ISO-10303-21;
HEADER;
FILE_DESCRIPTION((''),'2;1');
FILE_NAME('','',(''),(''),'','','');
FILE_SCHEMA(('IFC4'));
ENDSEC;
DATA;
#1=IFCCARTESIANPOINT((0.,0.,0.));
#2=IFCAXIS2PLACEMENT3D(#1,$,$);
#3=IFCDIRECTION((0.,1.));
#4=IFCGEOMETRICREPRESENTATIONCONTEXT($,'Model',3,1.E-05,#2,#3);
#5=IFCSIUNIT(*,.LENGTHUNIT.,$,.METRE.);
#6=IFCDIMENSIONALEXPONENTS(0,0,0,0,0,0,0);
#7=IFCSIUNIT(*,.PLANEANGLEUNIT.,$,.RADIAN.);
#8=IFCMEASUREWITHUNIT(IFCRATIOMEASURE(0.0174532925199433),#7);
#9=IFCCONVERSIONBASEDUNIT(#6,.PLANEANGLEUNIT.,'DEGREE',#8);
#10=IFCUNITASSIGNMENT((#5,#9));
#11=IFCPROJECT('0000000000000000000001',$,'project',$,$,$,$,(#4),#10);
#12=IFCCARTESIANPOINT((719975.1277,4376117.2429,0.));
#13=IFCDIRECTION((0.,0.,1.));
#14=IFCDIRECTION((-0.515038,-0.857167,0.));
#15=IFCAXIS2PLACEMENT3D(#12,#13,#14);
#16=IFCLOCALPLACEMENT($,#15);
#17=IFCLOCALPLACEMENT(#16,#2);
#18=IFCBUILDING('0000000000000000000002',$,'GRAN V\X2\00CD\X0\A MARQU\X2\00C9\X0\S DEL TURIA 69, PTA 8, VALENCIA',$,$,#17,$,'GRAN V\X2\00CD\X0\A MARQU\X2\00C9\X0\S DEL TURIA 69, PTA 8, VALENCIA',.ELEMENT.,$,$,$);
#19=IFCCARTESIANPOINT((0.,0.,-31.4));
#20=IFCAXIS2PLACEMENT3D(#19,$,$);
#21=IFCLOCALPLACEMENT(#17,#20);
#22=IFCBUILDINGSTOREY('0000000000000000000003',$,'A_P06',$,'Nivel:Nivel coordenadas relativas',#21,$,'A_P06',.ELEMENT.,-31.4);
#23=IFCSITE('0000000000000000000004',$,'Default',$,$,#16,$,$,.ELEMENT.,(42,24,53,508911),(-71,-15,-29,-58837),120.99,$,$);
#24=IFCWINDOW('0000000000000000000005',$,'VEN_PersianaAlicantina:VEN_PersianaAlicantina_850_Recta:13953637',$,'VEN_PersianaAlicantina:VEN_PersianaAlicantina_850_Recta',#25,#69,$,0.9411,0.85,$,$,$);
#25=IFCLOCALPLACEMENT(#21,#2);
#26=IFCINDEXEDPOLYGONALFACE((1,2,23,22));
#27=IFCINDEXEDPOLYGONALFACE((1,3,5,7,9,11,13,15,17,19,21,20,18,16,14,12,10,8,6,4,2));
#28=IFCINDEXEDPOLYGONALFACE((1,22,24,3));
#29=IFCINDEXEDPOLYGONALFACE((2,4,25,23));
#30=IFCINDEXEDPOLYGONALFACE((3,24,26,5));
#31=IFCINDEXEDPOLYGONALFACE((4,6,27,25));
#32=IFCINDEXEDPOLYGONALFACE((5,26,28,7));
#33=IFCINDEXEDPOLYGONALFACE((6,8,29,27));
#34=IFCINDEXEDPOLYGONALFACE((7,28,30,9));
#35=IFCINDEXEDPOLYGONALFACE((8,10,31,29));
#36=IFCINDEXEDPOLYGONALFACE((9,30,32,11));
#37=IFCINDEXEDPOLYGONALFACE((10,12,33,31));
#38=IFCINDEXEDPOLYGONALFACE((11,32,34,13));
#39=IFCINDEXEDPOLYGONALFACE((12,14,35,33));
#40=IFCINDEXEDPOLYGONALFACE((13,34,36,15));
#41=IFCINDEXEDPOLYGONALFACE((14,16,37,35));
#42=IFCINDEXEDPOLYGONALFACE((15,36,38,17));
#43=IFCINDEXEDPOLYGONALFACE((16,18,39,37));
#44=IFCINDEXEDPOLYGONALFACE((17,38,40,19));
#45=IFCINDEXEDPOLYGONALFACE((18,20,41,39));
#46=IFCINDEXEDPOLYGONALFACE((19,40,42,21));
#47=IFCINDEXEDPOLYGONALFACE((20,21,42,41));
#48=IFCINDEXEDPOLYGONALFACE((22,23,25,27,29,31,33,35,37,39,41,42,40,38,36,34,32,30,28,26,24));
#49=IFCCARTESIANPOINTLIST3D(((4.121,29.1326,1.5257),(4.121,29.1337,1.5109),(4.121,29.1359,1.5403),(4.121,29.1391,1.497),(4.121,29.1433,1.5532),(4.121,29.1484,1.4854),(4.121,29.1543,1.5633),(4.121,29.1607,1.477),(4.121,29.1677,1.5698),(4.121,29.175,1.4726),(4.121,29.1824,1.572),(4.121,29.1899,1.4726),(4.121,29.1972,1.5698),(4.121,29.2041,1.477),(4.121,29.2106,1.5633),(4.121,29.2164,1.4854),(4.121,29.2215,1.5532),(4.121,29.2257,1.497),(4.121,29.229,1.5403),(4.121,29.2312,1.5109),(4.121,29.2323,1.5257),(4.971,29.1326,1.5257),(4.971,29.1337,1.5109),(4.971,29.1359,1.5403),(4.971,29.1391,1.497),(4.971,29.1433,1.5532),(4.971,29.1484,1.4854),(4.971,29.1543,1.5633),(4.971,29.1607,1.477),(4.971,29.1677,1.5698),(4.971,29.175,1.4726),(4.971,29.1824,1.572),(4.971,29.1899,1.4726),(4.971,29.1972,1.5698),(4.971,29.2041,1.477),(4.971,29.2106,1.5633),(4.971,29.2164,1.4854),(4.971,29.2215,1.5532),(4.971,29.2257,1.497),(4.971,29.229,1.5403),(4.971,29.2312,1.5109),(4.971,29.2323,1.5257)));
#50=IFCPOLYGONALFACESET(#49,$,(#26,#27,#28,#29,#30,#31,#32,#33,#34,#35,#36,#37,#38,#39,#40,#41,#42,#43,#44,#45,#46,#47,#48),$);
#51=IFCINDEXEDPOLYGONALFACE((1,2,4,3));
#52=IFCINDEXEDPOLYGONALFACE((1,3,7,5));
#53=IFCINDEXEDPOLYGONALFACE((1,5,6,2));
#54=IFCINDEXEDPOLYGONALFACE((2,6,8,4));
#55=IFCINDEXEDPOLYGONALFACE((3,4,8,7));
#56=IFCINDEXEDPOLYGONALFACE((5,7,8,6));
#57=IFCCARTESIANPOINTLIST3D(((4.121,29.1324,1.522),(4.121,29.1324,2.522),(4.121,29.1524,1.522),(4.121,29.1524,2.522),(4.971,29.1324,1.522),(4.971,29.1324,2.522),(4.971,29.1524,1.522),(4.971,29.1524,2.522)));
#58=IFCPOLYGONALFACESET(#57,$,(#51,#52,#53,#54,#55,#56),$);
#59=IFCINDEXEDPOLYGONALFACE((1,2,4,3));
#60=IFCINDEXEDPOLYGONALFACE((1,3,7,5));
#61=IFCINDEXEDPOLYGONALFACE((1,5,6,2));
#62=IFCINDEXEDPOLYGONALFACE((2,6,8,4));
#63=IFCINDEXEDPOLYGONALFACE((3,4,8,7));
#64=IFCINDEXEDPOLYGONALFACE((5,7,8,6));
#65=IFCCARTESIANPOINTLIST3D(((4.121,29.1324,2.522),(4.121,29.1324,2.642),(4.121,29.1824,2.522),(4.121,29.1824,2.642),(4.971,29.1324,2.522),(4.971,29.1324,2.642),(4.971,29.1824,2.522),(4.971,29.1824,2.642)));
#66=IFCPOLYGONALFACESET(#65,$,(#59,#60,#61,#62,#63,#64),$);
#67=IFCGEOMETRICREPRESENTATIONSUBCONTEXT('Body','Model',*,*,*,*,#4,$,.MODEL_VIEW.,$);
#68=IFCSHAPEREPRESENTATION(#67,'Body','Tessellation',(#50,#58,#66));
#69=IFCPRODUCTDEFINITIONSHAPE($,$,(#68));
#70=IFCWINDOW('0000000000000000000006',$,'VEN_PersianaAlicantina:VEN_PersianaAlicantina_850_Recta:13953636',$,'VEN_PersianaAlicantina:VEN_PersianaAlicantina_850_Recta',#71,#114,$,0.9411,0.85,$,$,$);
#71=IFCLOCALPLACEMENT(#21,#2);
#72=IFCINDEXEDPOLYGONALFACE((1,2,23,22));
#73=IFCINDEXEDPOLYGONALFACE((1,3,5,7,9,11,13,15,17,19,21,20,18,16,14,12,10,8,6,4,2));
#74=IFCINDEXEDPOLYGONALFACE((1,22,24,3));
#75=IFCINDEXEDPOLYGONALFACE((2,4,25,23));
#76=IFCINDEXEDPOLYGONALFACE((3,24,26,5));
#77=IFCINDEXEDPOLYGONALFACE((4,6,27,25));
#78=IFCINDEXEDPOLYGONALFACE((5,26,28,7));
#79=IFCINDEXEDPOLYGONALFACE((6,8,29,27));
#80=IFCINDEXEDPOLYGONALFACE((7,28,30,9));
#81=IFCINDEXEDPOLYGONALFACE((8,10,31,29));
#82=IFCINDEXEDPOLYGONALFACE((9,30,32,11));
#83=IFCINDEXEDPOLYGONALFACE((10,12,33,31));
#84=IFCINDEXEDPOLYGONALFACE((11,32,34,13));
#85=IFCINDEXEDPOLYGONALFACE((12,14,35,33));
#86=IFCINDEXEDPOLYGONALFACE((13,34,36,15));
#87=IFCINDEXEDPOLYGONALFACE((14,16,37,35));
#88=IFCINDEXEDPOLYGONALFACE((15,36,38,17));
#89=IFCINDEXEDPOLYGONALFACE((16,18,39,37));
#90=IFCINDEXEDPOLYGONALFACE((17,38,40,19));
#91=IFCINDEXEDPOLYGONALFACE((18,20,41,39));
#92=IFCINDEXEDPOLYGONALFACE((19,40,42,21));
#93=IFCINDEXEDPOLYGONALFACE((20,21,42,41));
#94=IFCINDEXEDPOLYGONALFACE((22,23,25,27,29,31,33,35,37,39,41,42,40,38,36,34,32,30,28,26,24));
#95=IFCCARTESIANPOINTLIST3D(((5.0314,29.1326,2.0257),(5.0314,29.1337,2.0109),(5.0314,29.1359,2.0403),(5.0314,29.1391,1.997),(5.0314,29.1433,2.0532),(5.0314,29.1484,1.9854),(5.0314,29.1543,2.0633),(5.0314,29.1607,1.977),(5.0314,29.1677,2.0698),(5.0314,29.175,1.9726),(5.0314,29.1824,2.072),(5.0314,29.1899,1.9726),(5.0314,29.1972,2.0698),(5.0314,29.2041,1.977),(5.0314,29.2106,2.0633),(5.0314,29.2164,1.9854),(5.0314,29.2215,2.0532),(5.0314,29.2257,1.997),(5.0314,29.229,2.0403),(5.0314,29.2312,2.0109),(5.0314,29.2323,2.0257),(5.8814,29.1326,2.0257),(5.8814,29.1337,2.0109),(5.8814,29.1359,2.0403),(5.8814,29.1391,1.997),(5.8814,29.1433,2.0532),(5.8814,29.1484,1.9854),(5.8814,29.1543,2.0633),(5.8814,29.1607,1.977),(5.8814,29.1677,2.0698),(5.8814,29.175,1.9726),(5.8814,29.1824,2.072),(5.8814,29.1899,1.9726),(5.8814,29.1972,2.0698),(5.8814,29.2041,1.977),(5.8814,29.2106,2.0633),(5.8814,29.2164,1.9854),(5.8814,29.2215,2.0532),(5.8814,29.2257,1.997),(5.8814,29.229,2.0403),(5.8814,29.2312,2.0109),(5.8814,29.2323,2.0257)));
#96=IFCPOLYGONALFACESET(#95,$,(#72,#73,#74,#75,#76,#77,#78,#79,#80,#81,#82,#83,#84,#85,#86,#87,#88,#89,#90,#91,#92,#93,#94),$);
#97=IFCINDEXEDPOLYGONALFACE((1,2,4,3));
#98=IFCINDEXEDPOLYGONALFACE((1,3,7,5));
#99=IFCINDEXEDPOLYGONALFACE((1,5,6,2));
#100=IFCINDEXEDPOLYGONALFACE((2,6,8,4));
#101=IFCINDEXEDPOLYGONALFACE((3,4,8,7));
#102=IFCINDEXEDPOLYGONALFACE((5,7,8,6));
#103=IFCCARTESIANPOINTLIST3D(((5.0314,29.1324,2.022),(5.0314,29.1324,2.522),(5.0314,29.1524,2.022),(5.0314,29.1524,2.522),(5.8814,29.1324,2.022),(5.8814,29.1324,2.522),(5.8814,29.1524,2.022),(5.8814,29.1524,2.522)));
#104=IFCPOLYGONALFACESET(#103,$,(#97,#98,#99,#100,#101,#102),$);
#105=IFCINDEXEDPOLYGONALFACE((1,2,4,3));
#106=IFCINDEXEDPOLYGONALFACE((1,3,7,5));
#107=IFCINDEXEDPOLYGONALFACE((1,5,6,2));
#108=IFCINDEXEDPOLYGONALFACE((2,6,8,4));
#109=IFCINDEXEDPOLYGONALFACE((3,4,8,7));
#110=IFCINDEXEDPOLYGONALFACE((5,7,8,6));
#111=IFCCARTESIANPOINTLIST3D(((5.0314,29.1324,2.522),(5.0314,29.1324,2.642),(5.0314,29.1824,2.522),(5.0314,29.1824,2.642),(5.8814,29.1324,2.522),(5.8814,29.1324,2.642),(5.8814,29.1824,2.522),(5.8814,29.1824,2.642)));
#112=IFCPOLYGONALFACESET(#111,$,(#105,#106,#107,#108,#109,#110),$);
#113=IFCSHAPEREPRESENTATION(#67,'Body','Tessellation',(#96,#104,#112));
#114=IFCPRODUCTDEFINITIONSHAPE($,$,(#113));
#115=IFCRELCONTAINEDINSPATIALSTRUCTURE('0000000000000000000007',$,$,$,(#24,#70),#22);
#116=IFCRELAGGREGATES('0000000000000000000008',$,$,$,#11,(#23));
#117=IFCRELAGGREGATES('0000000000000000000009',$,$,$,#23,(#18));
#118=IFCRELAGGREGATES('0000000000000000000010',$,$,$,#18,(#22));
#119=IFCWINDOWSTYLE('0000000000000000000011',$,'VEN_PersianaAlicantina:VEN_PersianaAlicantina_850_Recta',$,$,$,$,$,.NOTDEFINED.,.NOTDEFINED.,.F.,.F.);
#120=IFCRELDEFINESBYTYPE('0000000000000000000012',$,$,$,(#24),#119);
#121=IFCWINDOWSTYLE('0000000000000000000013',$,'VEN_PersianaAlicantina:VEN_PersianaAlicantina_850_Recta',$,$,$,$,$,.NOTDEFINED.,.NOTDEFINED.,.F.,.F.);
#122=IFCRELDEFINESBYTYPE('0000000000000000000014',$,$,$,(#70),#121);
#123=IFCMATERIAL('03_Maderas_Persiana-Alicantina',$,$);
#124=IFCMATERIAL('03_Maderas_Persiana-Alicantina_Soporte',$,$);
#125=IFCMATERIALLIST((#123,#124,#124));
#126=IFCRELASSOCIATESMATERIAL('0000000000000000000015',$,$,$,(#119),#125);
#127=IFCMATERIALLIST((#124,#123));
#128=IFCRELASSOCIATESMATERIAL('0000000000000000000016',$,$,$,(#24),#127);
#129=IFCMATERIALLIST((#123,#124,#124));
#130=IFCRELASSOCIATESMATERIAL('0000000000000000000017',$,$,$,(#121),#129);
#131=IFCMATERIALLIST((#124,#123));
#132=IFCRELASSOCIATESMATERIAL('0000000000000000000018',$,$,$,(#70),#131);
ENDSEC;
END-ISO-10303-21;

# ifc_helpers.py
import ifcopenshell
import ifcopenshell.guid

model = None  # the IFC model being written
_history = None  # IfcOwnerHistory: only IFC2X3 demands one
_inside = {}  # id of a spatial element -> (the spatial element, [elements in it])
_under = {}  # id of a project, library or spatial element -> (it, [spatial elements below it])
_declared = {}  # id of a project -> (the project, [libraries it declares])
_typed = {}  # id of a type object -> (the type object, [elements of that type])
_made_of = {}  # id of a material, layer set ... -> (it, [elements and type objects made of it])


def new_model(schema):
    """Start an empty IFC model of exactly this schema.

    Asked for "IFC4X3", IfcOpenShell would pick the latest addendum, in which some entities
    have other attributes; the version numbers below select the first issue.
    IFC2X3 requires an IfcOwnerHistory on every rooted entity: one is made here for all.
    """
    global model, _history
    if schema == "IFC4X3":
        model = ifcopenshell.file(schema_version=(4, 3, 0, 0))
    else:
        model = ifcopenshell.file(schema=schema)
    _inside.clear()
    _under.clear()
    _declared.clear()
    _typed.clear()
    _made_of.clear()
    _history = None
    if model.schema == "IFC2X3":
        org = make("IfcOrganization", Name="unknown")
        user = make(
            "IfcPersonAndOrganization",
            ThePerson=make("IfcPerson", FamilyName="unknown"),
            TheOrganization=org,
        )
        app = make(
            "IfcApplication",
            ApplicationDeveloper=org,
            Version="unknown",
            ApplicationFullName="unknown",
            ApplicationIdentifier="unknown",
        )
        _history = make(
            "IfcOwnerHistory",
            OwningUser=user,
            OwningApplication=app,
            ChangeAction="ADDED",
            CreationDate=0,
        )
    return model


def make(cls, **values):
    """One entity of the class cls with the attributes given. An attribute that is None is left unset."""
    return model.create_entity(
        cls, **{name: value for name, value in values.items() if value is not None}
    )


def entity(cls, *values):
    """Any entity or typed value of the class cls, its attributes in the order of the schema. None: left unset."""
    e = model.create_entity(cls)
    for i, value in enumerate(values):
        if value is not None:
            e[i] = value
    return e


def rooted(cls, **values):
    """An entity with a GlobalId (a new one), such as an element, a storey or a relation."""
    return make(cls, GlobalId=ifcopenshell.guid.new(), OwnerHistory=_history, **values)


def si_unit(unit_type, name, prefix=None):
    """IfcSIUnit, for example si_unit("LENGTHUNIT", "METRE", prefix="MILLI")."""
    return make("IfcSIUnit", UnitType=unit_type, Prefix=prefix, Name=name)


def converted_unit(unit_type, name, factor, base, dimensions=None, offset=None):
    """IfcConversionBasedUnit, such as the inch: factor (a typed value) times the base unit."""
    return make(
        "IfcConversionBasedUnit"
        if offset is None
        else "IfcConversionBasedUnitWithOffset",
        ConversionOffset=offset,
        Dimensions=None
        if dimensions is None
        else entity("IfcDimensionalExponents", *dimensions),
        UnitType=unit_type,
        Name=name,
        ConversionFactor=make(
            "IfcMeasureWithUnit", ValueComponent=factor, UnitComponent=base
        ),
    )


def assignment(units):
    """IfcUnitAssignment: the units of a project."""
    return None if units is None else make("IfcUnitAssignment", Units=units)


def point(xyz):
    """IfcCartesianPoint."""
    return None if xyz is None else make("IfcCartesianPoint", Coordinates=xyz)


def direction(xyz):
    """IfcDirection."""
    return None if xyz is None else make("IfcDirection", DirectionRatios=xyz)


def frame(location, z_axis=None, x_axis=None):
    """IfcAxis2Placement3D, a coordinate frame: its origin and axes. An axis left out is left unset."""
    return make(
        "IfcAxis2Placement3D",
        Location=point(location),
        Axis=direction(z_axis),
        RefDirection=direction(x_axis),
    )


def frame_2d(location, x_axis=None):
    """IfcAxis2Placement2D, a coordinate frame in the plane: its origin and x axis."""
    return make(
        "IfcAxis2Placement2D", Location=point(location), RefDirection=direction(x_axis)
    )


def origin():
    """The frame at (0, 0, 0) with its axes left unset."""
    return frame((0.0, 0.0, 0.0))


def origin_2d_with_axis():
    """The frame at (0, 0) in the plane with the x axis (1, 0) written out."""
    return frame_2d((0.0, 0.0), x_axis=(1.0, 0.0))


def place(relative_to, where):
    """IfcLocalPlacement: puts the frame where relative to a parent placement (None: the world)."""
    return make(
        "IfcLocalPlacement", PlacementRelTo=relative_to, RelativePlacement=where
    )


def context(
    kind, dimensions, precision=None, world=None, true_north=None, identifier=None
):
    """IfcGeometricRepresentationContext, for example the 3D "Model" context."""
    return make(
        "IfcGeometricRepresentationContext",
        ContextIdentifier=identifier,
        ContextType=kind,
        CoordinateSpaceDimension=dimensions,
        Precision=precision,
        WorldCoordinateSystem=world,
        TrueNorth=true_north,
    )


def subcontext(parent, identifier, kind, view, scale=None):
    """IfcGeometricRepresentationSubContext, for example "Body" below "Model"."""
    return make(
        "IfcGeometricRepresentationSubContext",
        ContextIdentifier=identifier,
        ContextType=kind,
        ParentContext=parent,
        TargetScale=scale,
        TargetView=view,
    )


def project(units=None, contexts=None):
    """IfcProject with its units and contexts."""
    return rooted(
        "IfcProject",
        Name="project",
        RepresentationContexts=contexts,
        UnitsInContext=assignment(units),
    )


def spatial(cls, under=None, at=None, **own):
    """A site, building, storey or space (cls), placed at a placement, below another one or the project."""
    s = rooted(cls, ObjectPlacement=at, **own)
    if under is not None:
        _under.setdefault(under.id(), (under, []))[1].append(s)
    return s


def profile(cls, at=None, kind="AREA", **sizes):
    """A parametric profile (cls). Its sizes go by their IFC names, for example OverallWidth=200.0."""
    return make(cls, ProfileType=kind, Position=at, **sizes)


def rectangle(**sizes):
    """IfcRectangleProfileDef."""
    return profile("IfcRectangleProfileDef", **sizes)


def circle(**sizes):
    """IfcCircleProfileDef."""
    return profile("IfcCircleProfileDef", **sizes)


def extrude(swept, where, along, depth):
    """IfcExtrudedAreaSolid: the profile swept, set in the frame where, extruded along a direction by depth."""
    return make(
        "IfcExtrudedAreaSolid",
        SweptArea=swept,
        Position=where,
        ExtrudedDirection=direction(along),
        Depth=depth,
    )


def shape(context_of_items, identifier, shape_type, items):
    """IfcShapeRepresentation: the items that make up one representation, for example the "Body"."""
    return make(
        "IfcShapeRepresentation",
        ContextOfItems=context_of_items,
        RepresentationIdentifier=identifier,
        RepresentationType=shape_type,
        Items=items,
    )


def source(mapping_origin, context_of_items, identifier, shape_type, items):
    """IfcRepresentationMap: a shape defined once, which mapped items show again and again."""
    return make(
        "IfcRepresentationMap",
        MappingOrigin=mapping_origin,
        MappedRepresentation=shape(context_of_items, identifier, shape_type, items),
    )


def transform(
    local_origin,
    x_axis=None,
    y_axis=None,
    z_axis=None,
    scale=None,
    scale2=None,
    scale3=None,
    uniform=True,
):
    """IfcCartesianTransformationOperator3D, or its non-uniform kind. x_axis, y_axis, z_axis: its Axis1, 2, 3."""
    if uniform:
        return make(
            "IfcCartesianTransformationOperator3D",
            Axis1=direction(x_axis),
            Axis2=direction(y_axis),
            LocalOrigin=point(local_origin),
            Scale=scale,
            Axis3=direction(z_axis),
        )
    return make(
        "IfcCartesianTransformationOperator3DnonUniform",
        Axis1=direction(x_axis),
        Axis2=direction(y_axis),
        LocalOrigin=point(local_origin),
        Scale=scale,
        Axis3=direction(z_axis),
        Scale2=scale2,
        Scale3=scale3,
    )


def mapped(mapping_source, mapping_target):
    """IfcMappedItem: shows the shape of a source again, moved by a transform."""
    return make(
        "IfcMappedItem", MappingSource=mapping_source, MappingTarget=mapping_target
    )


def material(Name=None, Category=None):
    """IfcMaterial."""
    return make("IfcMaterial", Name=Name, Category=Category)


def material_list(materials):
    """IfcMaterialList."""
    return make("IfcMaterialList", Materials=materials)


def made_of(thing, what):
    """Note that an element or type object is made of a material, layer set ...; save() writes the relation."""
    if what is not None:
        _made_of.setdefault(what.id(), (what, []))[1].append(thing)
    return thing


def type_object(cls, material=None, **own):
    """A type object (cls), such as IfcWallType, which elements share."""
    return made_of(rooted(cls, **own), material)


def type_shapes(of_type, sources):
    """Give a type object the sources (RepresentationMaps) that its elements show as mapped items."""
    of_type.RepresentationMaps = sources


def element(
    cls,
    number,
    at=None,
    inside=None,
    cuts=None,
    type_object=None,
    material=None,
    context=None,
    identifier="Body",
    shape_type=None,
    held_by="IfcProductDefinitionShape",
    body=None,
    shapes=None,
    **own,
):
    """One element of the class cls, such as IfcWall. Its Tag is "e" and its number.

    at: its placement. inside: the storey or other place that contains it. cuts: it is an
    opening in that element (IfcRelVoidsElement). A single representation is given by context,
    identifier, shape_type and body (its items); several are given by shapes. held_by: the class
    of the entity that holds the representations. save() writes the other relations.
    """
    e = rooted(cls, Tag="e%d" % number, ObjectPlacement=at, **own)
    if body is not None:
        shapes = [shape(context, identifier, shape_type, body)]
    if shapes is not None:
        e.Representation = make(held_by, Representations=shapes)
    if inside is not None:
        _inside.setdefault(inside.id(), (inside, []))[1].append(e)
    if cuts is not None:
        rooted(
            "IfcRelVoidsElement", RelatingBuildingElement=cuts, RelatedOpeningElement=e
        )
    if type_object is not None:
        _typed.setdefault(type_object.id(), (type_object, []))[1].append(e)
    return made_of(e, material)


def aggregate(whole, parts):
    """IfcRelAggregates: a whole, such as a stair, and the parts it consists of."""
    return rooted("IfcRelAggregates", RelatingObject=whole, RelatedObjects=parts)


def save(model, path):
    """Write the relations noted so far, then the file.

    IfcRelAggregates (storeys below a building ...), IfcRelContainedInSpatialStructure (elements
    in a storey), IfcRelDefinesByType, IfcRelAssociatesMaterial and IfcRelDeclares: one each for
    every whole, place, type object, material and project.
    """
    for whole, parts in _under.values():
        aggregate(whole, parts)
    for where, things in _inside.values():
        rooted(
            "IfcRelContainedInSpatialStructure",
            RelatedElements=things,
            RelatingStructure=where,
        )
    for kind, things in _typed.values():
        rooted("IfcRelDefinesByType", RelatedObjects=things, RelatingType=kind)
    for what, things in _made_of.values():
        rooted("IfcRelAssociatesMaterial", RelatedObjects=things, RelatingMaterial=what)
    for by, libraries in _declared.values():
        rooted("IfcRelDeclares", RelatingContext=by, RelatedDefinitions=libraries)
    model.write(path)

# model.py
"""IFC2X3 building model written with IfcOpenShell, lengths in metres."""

from ifc_helpers import new_model, entity, si_unit, converted_unit, direction, frame, frame_2d, origin, origin_2d_with_axis, place, context, subcontext, project, spatial, rectangle, circle, extrude, source, transform, mapped, material, material_list, type_object, type_shapes, element, save


model = new_model("IFC2X3")

# Units and contexts
model_context = context("Model", 3, precision=1e-05, world=origin(), true_north=direction((0.0, 1.0)))
body_context = subcontext(model_context, "Body", "Model", "MODEL_VIEW")
ifc_project = project(units=[si_unit("LENGTHUNIT", "METRE"), converted_unit("PLANEANGLEUNIT", "DEGREE", entity("IfcRatioMeasure", 0.0174532925199433), si_unit("PLANEANGLEUNIT", "RADIAN"), dimensions=[0, 0, 0, 0, 0, 0, 0])], contexts=[model_context])

# Site, building, storey
site_placement = place(None, frame((719975.1277, 4376117.2429, 0.0), z_axis=(0.0, 0.0, 1.0), x_axis=(-0.515038, -0.857167, 0.0)))
site = spatial("IfcSite", under=ifc_project, at=site_placement, Name="Default", CompositionType="ELEMENT", RefLatitude=(42, 24, 53, 508911), RefLongitude=(-71, -15, -29, -58837), RefElevation=120.99)
building_placement = place(site_placement, origin())
building = spatial("IfcBuilding", under=site, at=building_placement, Name="GRAN VÍA MARQUÉS DEL TURIA 69, PTA 8, VALENCIA", LongName="GRAN VÍA MARQUÉS DEL TURIA 69, PTA 8, VALENCIA", CompositionType="ELEMENT")
storey_placement = place(building_placement, frame((0.0, 0.0, -31.4)))
storey = spatial("IfcBuildingStorey", under=building, at=storey_placement, Name="A_P06", ObjectType="Nivel:Nivel coordenadas relativas", LongName="A_P06", CompositionType="ELEMENT", Elevation=-31.4)

# Windows
ifc_material_1 = material(Name="03_Maderas_Persiana-Alicantina_Soporte")
ifc_material_2 = material(Name="03_Maderas_Persiana-Alicantina")
ifc_material_list_1 = material_list([ifc_material_1, ifc_material_2])
ifc_material_list_2 = material_list([ifc_material_2, ifc_material_1, ifc_material_1])
window_style_1 = type_object("IfcWindowStyle", Name="VEN_PersianaAlicantina:VEN_PersianaAlicantina_850_Recta", ConstructionType="NOTDEFINED", OperationType="NOTDEFINED", ParameterTakesPrecedence=False, Sizeable=False, material=ifc_material_list_2)
shared_shape_1 = source(origin(), body_context, "Body", "SweptSolid", [
    extrude(circle(Radius=0.05, at=frame_2d((0.0, 0.0), x_axis=(1.0, 0.0))), frame((-0.425, -0.5392, 0.05), z_axis=(1.0, 0.0, 0.0), x_axis=(0.0, 1.0, 0.0)), (0.0, 0.0, 1.0), 0.85),
    extrude(rectangle(XDim=0.85, YDim=1.0, at=frame_2d((0.0, 0.0), x_axis=(1.0, 0.0))), frame((0.0, -0.0392, 0.0), z_axis=(0.0, 0.0, 1.0), x_axis=(-1.0, 0.0, 0.0)), (0.0, 0.0, 1.0), 0.02),
    extrude(rectangle(XDim=0.85, YDim=0.12, at=frame_2d((0.0, 0.0), x_axis=(1.0, 0.0))), frame((0.0, 0.5208, 0.0), z_axis=(0.0, 0.0, 1.0), x_axis=(-1.0, 0.0, 0.0)), (0.0, 0.0, 1.0), 0.05),
])
type_shapes(window_style_1, [shared_shape_1])
window_1_placement = place(storey_placement, frame((4.546, 29.1324, 2.0612), z_axis=(0.0, 1.0, 0.0), x_axis=(-1.0, 0.0, 0.0)))
element("IfcWindow", 1, at=window_1_placement, inside=storey, type_object=window_style_1, material=ifc_material_list_1, Name="VEN_PersianaAlicantina:VEN_PersianaAlicantina_850_Recta:13953637", ObjectType="VEN_PersianaAlicantina:VEN_PersianaAlicantina_850_Recta", OverallHeight=0.9411, OverallWidth=0.85, context=body_context, shape_type="MappedRepresentation", body=[
    mapped(shared_shape_1, transform((0.0, 0.0, 0.0), scale=1.0)),
])
ifc_material_list_3 = material_list([ifc_material_1, ifc_material_2])
ifc_material_list_4 = material_list([ifc_material_2, ifc_material_1, ifc_material_1])
window_style_2 = type_object("IfcWindowStyle", Name="VEN_PersianaAlicantina:VEN_PersianaAlicantina_850_Recta", ConstructionType="NOTDEFINED", OperationType="NOTDEFINED", ParameterTakesPrecedence=False, Sizeable=False, material=ifc_material_list_4)
shared_shape_2 = source(origin(), body_context, "Body", "SweptSolid", [
    extrude(circle(Radius=0.05, at=frame_2d((0.0, 0.0), x_axis=(1.0, 0.0))), frame((-0.425, -0.0392, 0.05), z_axis=(1.0, 0.0, 0.0), x_axis=(0.0, 1.0, 0.0)), (0.0, 0.0, 1.0), 0.85),
    extrude(rectangle(XDim=0.85, YDim=0.5, at=origin_2d_with_axis()), frame((0.0, 0.2108, 0.0), z_axis=(0.0, 0.0, 1.0), x_axis=(-1.0, 0.0, 0.0)), (0.0, 0.0, 1.0), 0.02),
    extrude(rectangle(XDim=0.85, YDim=0.12, at=frame_2d((0.0, 0.0), x_axis=(1.0, 0.0))), frame((0.0, 0.5208, 0.0), z_axis=(0.0, 0.0, 1.0), x_axis=(-1.0, 0.0, 0.0)), (0.0, 0.0, 1.0), 0.05),
])
type_shapes(window_style_2, [shared_shape_2])
window_2_placement = place(storey_placement, frame((5.4564, 29.1324, 2.0612), z_axis=(0.0, 1.0, 0.0), x_axis=(-1.0, 0.0, 0.0)))
element("IfcWindow", 2, at=window_2_placement, inside=storey, type_object=window_style_2, material=ifc_material_list_3, Name="VEN_PersianaAlicantina:VEN_PersianaAlicantina_850_Recta:13953636", ObjectType="VEN_PersianaAlicantina:VEN_PersianaAlicantina_850_Recta", OverallHeight=0.9411, OverallWidth=0.85, context=body_context, shape_type="MappedRepresentation", body=[
    mapped(shared_shape_2, transform((0.0, 0.0, 0.0), scale=1.0)),
])

save(model, "model.ifc")
